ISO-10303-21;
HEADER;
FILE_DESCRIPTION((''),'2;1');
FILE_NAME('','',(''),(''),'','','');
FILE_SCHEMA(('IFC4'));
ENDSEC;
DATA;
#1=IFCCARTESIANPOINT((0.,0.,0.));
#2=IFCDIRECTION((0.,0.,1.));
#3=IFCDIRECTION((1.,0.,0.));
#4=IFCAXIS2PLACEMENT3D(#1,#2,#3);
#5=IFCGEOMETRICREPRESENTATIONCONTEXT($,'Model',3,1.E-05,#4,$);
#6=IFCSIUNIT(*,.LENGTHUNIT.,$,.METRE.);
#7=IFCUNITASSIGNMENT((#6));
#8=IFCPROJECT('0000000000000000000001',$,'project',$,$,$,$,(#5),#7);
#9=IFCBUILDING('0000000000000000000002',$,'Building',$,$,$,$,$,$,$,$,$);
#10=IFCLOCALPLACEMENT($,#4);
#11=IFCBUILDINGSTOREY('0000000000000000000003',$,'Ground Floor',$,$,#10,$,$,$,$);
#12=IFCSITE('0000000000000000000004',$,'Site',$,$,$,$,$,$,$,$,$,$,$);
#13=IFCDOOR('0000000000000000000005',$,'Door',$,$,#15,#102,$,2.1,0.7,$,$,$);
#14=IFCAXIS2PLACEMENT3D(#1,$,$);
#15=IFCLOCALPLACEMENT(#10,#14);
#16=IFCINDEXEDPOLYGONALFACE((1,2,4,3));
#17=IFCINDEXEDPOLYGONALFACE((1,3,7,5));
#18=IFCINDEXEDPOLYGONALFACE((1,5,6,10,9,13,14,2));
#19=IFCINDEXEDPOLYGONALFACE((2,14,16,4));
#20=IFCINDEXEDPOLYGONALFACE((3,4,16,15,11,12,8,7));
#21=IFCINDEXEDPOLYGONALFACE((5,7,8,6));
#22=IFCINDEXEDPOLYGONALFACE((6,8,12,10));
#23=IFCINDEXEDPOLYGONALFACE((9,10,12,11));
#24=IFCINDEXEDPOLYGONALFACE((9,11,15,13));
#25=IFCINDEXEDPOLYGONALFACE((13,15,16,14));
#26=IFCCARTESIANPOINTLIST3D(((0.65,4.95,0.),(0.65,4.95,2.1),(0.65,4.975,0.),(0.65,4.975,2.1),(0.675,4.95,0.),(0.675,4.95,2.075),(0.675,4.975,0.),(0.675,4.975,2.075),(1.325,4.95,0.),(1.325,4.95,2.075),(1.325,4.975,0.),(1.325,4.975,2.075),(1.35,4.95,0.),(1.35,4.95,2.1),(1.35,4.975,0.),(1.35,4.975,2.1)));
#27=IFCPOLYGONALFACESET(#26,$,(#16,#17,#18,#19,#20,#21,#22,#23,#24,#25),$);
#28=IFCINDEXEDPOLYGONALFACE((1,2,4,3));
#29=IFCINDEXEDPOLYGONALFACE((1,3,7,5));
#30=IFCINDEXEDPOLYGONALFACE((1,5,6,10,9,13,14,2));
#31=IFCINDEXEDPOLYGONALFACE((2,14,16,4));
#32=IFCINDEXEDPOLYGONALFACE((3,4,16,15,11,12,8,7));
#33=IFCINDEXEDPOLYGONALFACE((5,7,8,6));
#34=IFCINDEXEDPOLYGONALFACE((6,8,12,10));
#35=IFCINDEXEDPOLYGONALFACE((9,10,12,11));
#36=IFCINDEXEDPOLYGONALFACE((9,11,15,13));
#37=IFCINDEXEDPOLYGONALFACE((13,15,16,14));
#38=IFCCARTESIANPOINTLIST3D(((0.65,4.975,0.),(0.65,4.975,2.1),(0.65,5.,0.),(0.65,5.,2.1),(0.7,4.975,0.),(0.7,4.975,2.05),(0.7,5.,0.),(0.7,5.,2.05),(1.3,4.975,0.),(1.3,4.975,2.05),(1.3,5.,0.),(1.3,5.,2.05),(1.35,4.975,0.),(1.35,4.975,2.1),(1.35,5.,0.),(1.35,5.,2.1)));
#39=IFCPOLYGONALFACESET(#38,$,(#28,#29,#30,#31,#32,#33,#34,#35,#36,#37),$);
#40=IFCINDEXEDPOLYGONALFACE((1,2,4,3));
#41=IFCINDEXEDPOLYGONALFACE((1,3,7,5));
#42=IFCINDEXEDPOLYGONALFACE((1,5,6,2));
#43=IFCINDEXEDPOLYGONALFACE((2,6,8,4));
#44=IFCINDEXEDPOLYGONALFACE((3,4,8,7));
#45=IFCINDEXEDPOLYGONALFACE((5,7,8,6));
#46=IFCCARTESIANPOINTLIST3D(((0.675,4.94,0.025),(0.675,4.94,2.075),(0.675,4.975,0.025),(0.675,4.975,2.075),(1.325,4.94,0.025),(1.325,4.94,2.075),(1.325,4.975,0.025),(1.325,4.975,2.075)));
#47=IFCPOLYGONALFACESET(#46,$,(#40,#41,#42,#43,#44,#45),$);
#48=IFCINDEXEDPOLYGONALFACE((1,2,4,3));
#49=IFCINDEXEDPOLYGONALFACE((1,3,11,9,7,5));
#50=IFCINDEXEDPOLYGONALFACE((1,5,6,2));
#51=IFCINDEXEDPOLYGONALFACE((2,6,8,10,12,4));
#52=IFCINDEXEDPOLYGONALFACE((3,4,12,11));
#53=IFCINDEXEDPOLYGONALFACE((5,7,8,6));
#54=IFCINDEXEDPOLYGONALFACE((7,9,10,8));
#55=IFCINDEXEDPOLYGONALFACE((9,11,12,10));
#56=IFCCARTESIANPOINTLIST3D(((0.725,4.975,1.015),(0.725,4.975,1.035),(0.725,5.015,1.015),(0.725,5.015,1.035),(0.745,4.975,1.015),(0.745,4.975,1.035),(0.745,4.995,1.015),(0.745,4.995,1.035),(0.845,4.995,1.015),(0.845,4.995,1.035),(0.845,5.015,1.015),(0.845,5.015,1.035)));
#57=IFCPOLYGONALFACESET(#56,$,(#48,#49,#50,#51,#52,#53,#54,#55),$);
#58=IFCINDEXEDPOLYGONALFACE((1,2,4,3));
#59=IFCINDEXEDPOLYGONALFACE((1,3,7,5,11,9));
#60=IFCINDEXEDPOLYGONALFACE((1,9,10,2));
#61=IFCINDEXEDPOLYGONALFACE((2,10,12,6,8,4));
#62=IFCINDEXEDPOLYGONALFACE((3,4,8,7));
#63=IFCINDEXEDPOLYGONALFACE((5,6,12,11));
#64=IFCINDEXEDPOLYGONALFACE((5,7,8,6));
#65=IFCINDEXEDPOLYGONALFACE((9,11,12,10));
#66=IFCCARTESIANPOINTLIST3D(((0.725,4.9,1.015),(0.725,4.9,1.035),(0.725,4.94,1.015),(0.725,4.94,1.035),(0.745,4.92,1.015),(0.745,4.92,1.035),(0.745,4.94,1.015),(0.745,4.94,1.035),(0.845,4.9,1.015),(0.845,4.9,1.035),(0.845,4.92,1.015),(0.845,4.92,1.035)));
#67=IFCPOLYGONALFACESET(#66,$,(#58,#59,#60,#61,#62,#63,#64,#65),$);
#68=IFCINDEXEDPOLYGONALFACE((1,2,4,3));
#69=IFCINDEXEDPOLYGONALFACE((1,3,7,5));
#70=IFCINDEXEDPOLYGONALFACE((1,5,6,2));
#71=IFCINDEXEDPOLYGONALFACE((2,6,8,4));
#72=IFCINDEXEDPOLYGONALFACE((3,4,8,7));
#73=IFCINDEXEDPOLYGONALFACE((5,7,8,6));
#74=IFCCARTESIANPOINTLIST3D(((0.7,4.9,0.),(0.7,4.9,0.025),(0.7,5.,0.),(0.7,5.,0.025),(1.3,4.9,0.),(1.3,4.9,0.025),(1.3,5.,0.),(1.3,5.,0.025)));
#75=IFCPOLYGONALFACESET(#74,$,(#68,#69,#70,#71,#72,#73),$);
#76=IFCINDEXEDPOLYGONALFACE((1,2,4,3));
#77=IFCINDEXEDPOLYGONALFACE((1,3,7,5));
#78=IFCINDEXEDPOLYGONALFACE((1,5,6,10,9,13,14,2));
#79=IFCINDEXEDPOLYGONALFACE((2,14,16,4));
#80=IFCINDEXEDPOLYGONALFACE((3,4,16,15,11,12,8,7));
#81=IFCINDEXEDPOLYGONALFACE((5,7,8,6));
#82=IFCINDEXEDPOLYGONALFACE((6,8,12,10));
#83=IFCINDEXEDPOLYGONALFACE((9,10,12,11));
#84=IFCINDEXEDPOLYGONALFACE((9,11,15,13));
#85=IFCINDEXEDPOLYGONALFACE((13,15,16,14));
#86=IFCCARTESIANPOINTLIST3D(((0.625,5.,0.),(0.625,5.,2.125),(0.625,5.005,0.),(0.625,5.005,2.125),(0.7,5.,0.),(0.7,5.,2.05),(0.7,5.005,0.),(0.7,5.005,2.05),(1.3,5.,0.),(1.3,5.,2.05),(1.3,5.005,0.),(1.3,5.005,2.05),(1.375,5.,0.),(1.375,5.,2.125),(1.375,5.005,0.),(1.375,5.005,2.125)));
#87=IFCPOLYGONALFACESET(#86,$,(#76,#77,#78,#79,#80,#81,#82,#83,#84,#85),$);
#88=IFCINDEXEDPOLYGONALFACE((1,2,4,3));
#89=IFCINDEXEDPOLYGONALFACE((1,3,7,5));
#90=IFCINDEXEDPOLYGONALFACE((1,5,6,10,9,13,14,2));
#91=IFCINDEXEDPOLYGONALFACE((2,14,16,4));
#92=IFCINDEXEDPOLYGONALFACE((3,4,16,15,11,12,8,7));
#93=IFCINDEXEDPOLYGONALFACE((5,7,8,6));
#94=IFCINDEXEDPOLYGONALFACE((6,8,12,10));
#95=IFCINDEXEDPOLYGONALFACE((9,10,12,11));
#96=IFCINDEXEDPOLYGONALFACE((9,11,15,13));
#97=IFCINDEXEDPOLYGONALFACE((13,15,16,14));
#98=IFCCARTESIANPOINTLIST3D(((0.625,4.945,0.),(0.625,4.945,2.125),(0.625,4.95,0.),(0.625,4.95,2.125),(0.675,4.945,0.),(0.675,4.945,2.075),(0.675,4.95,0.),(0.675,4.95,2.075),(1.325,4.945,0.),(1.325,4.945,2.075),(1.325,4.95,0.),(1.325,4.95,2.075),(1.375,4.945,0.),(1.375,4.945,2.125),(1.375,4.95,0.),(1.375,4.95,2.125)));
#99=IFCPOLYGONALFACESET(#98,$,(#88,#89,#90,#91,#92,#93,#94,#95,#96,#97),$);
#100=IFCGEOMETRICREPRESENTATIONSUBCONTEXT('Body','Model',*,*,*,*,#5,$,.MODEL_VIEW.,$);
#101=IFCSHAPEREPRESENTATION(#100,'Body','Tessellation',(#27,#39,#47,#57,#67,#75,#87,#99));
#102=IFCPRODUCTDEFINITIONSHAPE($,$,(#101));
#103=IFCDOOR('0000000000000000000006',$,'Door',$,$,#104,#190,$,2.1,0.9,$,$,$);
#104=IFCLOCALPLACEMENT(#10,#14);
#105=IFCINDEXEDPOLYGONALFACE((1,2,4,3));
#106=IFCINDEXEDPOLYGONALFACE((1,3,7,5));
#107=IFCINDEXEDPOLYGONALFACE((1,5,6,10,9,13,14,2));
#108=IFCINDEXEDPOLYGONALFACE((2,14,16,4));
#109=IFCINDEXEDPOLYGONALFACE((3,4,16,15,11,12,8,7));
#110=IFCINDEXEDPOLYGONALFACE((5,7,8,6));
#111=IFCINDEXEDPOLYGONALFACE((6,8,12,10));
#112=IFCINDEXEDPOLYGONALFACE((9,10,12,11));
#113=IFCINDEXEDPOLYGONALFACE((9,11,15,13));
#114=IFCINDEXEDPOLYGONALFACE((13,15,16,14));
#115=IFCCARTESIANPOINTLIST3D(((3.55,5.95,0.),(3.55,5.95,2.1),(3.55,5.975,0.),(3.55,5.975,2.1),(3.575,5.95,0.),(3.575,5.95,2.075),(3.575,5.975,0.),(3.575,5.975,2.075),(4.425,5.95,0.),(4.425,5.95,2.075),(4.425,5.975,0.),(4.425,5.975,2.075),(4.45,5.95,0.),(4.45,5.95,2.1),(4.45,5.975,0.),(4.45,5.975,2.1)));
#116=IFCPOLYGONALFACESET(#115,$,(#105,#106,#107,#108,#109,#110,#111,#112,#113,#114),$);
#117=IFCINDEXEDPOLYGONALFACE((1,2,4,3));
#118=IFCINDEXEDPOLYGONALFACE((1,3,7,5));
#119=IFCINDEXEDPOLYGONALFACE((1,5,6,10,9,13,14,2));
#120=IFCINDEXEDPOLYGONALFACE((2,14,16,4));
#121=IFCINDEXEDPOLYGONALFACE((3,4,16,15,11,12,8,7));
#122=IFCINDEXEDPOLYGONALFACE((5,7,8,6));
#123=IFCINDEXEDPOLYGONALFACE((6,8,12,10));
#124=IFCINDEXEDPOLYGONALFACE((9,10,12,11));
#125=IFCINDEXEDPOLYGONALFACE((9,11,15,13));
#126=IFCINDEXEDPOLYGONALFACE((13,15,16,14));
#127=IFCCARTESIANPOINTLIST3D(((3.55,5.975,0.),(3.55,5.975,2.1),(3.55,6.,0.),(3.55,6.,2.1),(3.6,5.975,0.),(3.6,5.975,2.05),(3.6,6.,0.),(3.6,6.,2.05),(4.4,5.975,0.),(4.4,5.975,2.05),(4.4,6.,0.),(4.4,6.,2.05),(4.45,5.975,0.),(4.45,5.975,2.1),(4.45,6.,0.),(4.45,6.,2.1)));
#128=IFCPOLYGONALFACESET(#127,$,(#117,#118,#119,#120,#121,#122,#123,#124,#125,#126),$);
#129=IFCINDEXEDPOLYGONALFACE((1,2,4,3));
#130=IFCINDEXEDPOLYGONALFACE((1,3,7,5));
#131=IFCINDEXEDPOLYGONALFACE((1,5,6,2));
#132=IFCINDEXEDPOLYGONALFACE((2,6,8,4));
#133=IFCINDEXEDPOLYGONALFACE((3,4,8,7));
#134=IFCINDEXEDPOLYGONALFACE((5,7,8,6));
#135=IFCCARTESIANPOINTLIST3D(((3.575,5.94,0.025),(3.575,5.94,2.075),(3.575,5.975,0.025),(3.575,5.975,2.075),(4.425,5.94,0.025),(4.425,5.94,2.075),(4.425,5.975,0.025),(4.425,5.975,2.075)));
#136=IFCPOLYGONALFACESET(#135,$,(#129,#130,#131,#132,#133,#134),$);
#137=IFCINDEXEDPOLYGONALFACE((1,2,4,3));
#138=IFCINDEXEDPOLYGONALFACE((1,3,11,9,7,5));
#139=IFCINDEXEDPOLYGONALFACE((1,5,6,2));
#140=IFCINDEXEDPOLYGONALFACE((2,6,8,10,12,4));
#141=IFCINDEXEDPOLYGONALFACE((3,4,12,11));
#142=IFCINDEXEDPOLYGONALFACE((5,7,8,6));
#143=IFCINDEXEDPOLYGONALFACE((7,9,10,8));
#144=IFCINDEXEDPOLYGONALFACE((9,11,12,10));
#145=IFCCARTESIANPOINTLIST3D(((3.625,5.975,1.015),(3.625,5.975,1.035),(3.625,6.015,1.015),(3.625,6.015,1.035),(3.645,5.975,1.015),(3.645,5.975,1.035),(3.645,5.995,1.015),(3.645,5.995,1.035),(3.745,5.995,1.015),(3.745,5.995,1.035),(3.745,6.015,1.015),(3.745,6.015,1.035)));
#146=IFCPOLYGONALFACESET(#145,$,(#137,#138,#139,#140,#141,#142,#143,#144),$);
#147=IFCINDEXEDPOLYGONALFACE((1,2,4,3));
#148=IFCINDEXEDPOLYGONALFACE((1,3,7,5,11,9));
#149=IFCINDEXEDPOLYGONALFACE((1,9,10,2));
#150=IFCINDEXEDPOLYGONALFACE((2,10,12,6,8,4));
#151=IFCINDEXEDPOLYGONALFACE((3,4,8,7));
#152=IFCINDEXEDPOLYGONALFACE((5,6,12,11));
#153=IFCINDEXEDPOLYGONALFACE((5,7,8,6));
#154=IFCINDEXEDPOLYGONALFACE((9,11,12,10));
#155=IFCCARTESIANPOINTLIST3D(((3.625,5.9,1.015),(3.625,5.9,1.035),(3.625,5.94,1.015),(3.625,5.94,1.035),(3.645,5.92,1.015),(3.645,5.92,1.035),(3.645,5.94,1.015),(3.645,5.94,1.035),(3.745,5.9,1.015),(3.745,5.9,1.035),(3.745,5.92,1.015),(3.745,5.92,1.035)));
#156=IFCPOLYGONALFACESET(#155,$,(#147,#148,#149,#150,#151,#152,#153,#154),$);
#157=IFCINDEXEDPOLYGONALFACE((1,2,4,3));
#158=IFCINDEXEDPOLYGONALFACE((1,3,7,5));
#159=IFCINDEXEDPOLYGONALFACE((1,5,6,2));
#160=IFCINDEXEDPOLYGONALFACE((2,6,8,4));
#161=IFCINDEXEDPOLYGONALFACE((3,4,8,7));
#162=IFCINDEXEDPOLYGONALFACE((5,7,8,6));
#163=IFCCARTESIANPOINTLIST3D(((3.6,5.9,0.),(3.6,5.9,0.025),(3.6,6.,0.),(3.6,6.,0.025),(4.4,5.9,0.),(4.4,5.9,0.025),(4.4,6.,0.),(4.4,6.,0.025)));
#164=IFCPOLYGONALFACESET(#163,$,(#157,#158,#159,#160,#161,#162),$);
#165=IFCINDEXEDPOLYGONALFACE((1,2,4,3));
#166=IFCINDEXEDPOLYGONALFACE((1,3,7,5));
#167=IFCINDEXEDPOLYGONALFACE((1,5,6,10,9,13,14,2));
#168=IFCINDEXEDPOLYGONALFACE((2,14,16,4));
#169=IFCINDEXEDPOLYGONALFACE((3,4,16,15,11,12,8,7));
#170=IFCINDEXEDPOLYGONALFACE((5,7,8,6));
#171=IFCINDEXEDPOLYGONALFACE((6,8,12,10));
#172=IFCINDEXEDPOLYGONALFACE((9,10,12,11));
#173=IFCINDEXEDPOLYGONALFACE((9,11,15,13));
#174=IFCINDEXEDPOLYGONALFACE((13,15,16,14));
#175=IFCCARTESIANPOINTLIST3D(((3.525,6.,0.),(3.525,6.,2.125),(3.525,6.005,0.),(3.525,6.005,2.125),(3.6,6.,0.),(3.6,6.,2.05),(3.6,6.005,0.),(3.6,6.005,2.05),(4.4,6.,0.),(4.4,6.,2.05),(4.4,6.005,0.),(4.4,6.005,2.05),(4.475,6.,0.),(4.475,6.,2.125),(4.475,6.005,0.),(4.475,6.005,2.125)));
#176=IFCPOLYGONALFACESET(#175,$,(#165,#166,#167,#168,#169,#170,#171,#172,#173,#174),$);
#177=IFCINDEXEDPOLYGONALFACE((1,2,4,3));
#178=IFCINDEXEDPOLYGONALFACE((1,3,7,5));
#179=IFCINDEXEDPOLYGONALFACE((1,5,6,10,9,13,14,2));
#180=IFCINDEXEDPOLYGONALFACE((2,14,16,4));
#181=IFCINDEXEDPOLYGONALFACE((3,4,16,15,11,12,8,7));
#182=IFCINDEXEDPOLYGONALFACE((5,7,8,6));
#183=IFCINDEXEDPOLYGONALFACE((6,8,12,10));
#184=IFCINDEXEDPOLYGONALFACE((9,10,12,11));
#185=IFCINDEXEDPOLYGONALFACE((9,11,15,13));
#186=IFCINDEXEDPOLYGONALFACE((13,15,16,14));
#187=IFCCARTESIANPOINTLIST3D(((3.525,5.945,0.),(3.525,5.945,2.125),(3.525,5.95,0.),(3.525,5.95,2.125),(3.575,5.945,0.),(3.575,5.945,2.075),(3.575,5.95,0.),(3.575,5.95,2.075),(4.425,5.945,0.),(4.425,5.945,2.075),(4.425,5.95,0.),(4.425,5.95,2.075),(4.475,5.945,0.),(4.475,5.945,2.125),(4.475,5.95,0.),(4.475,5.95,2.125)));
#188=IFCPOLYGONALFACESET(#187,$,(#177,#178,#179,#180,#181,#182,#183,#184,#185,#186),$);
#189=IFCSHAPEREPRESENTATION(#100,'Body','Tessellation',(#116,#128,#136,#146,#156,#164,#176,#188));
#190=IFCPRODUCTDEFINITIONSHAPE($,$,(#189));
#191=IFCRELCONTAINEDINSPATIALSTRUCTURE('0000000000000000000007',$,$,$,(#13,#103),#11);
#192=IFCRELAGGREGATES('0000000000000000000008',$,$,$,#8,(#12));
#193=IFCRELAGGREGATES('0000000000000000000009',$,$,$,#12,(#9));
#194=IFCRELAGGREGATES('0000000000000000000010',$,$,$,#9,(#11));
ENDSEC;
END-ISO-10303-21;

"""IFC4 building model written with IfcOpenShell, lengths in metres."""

from ifc_helpers import new_model, si_unit, frame, origin_with_axes, place, context, subcontext, project, spatial, line, indexed_curve, outline, extrude, element, save


model = new_model("IFC4")

# Units and contexts
model_context = context("Model", 3, precision=1e-05, world=origin_with_axes())
body_context = subcontext(model_context, "Body", "Model", "MODEL_VIEW")
ifc_project = project(units=[si_unit("LENGTHUNIT", "METRE")], contexts=[model_context])

# Site, building, storey
site = spatial("IfcSite", under=ifc_project, Name="Site")
building = spatial("IfcBuilding", under=site, Name="Building")
storey_placement = place(None, origin_with_axes())
storey = spatial("IfcBuildingStorey", under=building, at=storey_placement, Name="Ground Floor")

# Doors
door_1_placement = place(storey_placement, frame((1.35, 5.0, 0.0), z_axis=(0.0, 0.0, 1.0), x_axis=(-1.0, 0.0, 0.0)))
element("IfcDoor", 1, at=door_1_placement, inside=storey, Name="Door", OverallHeight=2.1, OverallWidth=0.7, context=body_context, shape_type="SweptSolid", body=[
    extrude(outline(indexed_curve([(0.0, 0.0), (0.0, 2.1), (0.7, 2.1), (0.7, 0.0), (0.675, 0.0), (0.675, 2.075), (0.025, 2.075), (0.025, 0.0)], segments=[line(1, 2, 3, 4, 5, 6, 7, 8, 1)])), frame((0.0, 0.025, 0.0), z_axis=(0.0, -1.0, 0.0), x_axis=(1.0, 0.0, 0.0)), (0.0, 0.0, -1.0), 0.025),
    extrude(outline(indexed_curve([(0.0, 0.0), (0.0, 2.1), (0.7, 2.1), (0.7, 0.0), (0.65, 0.0), (0.65, 2.05), (0.05, 2.05), (0.05, 0.0)], segments=[line(1, 2, 3, 4, 5, 6, 7, 8, 1)])), frame((0.0, 0.0, 0.0), z_axis=(0.0, -1.0, 0.0), x_axis=(1.0, 0.0, 0.0)), (0.0, 0.0, -1.0), 0.025),
    extrude(outline(indexed_curve([(0.0, 0.0), (0.65, 0.0), (0.65, 0.035), (0.0, 0.035)], segments=[line(1, 2, 3, 4, 1)])), frame((0.025, 0.025, 0.025), z_axis=(0.0, 0.0, 1.0), x_axis=(1.0, 0.0, 0.0)), (0.0, 0.0, 1.0), 2.05),
    extrude(outline(indexed_curve([(0.0, 0.0), (0.0, -0.04), (-0.12, -0.04), (-0.12, -0.02), (-0.02, -0.02), (-0.02, 0.0)], segments=[line(1, 2, 3, 4, 5, 6, 1)])), frame((0.625, 0.025, 1.015), z_axis=(0.0, 0.0, 1.0), x_axis=(1.0, 0.0, 0.0)), (0.0, 0.0, 1.0), 0.02),
    extrude(outline(indexed_curve([(0.0, 0.0), (0.0, 0.04), (-0.12, 0.04), (-0.12, 0.02), (-0.02, 0.02), (-0.02, 0.0)], segments=[line(1, 2, 3, 4, 5, 6, 1)])), frame((0.625, 0.06, 1.015), z_axis=(0.0, 0.0, 1.0), x_axis=(1.0, 0.0, 0.0)), (0.0, 0.0, 1.0), 0.02),
    extrude(outline(indexed_curve([(0.0, 0.0), (0.6, 0.0), (0.6, 0.1), (0.0, 0.1)], segments=[line(1, 2, 3, 4, 1)])), frame((0.05, 0.0, 0.0), z_axis=(0.0, 0.0, 1.0), x_axis=(1.0, 0.0, 0.0)), (0.0, 0.0, 1.0), 0.025),
    extrude(outline(indexed_curve([(0.0, 0.0), (0.0, 2.125), (0.75, 2.125), (0.75, 0.0), (0.675, 0.0), (0.675, 2.05), (0.075, 2.05), (0.075, 0.0)], segments=[line(1, 2, 3, 4, 5, 6, 7, 8, 1)])), frame((-0.025, -0.005, 0.0), z_axis=(0.0, -1.0, 0.0), x_axis=(1.0, 0.0, 0.0)), (0.0, 0.0, -1.0), 0.005),
    extrude(outline(indexed_curve([(0.0, 0.0), (0.0, 2.125), (0.75, 2.125), (0.75, 0.0), (0.7, 0.0), (0.7, 2.075), (0.05, 2.075), (0.05, 0.0)], segments=[line(1, 2, 3, 4, 5, 6, 7, 8, 1)])), frame((-0.025, 0.05, 0.0), z_axis=(0.0, -1.0, 0.0), x_axis=(1.0, 0.0, 0.0)), (0.0, 0.0, -1.0), 0.005),
])
door_2_placement = place(storey_placement, frame((4.45, 6.0, 0.0), z_axis=(0.0, 0.0, 1.0), x_axis=(-1.0, 0.0, 0.0)))
element("IfcDoor", 2, at=door_2_placement, inside=storey, Name="Door", OverallHeight=2.1, OverallWidth=0.9, context=body_context, shape_type="SweptSolid", body=[
    extrude(outline(indexed_curve([(0.0, 0.0), (0.0, 2.1), (0.9, 2.1), (0.9, 0.0), (0.875, 0.0), (0.875, 2.075), (0.025, 2.075), (0.025, 0.0)], segments=[line(1, 2, 3, 4, 5, 6, 7, 8, 1)])), frame((0.0, 0.025, 0.0), z_axis=(0.0, -1.0, 0.0), x_axis=(1.0, 0.0, 0.0)), (0.0, 0.0, -1.0), 0.025),
    extrude(outline(indexed_curve([(0.0, 0.0), (0.0, 2.1), (0.9, 2.1), (0.9, 0.0), (0.85, 0.0), (0.85, 2.05), (0.05, 2.05), (0.05, 0.0)], segments=[line(1, 2, 3, 4, 5, 6, 7, 8, 1)])), frame((0.0, 0.0, 0.0), z_axis=(0.0, -1.0, 0.0), x_axis=(1.0, 0.0, 0.0)), (0.0, 0.0, -1.0), 0.025),
    extrude(outline(indexed_curve([(0.0, 0.0), (0.85, 0.0), (0.85, 0.035), (0.0, 0.035)], segments=[line(1, 2, 3, 4, 1)])), frame((0.025, 0.025, 0.025), z_axis=(0.0, 0.0, 1.0), x_axis=(1.0, 0.0, 0.0)), (0.0, 0.0, 1.0), 2.05),
    extrude(outline(indexed_curve([(0.0, 0.0), (0.0, -0.04), (-0.12, -0.04), (-0.12, -0.02), (-0.02, -0.02), (-0.02, 0.0)], segments=[line(1, 2, 3, 4, 5, 6, 1)])), frame((0.825, 0.025, 1.015), z_axis=(0.0, 0.0, 1.0), x_axis=(1.0, 0.0, 0.0)), (0.0, 0.0, 1.0), 0.02),
    extrude(outline(indexed_curve([(0.0, 0.0), (0.0, 0.04), (-0.12, 0.04), (-0.12, 0.02), (-0.02, 0.02), (-0.02, 0.0)], segments=[line(1, 2, 3, 4, 5, 6, 1)])), frame((0.825, 0.06, 1.015), z_axis=(0.0, 0.0, 1.0), x_axis=(1.0, 0.0, 0.0)), (0.0, 0.0, 1.0), 0.02),
    extrude(outline(indexed_curve([(0.0, 0.0), (0.8, 0.0), (0.8, 0.1), (0.0, 0.1)], segments=[line(1, 2, 3, 4, 1)])), frame((0.05, 0.0, 0.0), z_axis=(0.0, 0.0, 1.0), x_axis=(1.0, 0.0, 0.0)), (0.0, 0.0, 1.0), 0.025),
    extrude(outline(indexed_curve([(0.0, 0.0), (0.0, 2.125), (0.95, 2.125), (0.95, 0.0), (0.875, 0.0), (0.875, 2.05), (0.075, 2.05), (0.075, 0.0)], segments=[line(1, 2, 3, 4, 5, 6, 7, 8, 1)])), frame((-0.025, -0.005, 0.0), z_axis=(0.0, -1.0, 0.0), x_axis=(1.0, 0.0, 0.0)), (0.0, 0.0, -1.0), 0.005),
    extrude(outline(indexed_curve([(0.0, 0.0), (0.0, 2.125), (0.95, 2.125), (0.95, 0.0), (0.9, 0.0), (0.9, 2.075), (0.05, 2.075), (0.05, 0.0)], segments=[line(1, 2, 3, 4, 5, 6, 7, 8, 1)])), frame((-0.025, 0.05, 0.0), z_axis=(0.0, -1.0, 0.0), x_axis=(1.0, 0.0, 0.0)), (0.0, 0.0, -1.0), 0.005),
])

save(model, "model.ifc")
